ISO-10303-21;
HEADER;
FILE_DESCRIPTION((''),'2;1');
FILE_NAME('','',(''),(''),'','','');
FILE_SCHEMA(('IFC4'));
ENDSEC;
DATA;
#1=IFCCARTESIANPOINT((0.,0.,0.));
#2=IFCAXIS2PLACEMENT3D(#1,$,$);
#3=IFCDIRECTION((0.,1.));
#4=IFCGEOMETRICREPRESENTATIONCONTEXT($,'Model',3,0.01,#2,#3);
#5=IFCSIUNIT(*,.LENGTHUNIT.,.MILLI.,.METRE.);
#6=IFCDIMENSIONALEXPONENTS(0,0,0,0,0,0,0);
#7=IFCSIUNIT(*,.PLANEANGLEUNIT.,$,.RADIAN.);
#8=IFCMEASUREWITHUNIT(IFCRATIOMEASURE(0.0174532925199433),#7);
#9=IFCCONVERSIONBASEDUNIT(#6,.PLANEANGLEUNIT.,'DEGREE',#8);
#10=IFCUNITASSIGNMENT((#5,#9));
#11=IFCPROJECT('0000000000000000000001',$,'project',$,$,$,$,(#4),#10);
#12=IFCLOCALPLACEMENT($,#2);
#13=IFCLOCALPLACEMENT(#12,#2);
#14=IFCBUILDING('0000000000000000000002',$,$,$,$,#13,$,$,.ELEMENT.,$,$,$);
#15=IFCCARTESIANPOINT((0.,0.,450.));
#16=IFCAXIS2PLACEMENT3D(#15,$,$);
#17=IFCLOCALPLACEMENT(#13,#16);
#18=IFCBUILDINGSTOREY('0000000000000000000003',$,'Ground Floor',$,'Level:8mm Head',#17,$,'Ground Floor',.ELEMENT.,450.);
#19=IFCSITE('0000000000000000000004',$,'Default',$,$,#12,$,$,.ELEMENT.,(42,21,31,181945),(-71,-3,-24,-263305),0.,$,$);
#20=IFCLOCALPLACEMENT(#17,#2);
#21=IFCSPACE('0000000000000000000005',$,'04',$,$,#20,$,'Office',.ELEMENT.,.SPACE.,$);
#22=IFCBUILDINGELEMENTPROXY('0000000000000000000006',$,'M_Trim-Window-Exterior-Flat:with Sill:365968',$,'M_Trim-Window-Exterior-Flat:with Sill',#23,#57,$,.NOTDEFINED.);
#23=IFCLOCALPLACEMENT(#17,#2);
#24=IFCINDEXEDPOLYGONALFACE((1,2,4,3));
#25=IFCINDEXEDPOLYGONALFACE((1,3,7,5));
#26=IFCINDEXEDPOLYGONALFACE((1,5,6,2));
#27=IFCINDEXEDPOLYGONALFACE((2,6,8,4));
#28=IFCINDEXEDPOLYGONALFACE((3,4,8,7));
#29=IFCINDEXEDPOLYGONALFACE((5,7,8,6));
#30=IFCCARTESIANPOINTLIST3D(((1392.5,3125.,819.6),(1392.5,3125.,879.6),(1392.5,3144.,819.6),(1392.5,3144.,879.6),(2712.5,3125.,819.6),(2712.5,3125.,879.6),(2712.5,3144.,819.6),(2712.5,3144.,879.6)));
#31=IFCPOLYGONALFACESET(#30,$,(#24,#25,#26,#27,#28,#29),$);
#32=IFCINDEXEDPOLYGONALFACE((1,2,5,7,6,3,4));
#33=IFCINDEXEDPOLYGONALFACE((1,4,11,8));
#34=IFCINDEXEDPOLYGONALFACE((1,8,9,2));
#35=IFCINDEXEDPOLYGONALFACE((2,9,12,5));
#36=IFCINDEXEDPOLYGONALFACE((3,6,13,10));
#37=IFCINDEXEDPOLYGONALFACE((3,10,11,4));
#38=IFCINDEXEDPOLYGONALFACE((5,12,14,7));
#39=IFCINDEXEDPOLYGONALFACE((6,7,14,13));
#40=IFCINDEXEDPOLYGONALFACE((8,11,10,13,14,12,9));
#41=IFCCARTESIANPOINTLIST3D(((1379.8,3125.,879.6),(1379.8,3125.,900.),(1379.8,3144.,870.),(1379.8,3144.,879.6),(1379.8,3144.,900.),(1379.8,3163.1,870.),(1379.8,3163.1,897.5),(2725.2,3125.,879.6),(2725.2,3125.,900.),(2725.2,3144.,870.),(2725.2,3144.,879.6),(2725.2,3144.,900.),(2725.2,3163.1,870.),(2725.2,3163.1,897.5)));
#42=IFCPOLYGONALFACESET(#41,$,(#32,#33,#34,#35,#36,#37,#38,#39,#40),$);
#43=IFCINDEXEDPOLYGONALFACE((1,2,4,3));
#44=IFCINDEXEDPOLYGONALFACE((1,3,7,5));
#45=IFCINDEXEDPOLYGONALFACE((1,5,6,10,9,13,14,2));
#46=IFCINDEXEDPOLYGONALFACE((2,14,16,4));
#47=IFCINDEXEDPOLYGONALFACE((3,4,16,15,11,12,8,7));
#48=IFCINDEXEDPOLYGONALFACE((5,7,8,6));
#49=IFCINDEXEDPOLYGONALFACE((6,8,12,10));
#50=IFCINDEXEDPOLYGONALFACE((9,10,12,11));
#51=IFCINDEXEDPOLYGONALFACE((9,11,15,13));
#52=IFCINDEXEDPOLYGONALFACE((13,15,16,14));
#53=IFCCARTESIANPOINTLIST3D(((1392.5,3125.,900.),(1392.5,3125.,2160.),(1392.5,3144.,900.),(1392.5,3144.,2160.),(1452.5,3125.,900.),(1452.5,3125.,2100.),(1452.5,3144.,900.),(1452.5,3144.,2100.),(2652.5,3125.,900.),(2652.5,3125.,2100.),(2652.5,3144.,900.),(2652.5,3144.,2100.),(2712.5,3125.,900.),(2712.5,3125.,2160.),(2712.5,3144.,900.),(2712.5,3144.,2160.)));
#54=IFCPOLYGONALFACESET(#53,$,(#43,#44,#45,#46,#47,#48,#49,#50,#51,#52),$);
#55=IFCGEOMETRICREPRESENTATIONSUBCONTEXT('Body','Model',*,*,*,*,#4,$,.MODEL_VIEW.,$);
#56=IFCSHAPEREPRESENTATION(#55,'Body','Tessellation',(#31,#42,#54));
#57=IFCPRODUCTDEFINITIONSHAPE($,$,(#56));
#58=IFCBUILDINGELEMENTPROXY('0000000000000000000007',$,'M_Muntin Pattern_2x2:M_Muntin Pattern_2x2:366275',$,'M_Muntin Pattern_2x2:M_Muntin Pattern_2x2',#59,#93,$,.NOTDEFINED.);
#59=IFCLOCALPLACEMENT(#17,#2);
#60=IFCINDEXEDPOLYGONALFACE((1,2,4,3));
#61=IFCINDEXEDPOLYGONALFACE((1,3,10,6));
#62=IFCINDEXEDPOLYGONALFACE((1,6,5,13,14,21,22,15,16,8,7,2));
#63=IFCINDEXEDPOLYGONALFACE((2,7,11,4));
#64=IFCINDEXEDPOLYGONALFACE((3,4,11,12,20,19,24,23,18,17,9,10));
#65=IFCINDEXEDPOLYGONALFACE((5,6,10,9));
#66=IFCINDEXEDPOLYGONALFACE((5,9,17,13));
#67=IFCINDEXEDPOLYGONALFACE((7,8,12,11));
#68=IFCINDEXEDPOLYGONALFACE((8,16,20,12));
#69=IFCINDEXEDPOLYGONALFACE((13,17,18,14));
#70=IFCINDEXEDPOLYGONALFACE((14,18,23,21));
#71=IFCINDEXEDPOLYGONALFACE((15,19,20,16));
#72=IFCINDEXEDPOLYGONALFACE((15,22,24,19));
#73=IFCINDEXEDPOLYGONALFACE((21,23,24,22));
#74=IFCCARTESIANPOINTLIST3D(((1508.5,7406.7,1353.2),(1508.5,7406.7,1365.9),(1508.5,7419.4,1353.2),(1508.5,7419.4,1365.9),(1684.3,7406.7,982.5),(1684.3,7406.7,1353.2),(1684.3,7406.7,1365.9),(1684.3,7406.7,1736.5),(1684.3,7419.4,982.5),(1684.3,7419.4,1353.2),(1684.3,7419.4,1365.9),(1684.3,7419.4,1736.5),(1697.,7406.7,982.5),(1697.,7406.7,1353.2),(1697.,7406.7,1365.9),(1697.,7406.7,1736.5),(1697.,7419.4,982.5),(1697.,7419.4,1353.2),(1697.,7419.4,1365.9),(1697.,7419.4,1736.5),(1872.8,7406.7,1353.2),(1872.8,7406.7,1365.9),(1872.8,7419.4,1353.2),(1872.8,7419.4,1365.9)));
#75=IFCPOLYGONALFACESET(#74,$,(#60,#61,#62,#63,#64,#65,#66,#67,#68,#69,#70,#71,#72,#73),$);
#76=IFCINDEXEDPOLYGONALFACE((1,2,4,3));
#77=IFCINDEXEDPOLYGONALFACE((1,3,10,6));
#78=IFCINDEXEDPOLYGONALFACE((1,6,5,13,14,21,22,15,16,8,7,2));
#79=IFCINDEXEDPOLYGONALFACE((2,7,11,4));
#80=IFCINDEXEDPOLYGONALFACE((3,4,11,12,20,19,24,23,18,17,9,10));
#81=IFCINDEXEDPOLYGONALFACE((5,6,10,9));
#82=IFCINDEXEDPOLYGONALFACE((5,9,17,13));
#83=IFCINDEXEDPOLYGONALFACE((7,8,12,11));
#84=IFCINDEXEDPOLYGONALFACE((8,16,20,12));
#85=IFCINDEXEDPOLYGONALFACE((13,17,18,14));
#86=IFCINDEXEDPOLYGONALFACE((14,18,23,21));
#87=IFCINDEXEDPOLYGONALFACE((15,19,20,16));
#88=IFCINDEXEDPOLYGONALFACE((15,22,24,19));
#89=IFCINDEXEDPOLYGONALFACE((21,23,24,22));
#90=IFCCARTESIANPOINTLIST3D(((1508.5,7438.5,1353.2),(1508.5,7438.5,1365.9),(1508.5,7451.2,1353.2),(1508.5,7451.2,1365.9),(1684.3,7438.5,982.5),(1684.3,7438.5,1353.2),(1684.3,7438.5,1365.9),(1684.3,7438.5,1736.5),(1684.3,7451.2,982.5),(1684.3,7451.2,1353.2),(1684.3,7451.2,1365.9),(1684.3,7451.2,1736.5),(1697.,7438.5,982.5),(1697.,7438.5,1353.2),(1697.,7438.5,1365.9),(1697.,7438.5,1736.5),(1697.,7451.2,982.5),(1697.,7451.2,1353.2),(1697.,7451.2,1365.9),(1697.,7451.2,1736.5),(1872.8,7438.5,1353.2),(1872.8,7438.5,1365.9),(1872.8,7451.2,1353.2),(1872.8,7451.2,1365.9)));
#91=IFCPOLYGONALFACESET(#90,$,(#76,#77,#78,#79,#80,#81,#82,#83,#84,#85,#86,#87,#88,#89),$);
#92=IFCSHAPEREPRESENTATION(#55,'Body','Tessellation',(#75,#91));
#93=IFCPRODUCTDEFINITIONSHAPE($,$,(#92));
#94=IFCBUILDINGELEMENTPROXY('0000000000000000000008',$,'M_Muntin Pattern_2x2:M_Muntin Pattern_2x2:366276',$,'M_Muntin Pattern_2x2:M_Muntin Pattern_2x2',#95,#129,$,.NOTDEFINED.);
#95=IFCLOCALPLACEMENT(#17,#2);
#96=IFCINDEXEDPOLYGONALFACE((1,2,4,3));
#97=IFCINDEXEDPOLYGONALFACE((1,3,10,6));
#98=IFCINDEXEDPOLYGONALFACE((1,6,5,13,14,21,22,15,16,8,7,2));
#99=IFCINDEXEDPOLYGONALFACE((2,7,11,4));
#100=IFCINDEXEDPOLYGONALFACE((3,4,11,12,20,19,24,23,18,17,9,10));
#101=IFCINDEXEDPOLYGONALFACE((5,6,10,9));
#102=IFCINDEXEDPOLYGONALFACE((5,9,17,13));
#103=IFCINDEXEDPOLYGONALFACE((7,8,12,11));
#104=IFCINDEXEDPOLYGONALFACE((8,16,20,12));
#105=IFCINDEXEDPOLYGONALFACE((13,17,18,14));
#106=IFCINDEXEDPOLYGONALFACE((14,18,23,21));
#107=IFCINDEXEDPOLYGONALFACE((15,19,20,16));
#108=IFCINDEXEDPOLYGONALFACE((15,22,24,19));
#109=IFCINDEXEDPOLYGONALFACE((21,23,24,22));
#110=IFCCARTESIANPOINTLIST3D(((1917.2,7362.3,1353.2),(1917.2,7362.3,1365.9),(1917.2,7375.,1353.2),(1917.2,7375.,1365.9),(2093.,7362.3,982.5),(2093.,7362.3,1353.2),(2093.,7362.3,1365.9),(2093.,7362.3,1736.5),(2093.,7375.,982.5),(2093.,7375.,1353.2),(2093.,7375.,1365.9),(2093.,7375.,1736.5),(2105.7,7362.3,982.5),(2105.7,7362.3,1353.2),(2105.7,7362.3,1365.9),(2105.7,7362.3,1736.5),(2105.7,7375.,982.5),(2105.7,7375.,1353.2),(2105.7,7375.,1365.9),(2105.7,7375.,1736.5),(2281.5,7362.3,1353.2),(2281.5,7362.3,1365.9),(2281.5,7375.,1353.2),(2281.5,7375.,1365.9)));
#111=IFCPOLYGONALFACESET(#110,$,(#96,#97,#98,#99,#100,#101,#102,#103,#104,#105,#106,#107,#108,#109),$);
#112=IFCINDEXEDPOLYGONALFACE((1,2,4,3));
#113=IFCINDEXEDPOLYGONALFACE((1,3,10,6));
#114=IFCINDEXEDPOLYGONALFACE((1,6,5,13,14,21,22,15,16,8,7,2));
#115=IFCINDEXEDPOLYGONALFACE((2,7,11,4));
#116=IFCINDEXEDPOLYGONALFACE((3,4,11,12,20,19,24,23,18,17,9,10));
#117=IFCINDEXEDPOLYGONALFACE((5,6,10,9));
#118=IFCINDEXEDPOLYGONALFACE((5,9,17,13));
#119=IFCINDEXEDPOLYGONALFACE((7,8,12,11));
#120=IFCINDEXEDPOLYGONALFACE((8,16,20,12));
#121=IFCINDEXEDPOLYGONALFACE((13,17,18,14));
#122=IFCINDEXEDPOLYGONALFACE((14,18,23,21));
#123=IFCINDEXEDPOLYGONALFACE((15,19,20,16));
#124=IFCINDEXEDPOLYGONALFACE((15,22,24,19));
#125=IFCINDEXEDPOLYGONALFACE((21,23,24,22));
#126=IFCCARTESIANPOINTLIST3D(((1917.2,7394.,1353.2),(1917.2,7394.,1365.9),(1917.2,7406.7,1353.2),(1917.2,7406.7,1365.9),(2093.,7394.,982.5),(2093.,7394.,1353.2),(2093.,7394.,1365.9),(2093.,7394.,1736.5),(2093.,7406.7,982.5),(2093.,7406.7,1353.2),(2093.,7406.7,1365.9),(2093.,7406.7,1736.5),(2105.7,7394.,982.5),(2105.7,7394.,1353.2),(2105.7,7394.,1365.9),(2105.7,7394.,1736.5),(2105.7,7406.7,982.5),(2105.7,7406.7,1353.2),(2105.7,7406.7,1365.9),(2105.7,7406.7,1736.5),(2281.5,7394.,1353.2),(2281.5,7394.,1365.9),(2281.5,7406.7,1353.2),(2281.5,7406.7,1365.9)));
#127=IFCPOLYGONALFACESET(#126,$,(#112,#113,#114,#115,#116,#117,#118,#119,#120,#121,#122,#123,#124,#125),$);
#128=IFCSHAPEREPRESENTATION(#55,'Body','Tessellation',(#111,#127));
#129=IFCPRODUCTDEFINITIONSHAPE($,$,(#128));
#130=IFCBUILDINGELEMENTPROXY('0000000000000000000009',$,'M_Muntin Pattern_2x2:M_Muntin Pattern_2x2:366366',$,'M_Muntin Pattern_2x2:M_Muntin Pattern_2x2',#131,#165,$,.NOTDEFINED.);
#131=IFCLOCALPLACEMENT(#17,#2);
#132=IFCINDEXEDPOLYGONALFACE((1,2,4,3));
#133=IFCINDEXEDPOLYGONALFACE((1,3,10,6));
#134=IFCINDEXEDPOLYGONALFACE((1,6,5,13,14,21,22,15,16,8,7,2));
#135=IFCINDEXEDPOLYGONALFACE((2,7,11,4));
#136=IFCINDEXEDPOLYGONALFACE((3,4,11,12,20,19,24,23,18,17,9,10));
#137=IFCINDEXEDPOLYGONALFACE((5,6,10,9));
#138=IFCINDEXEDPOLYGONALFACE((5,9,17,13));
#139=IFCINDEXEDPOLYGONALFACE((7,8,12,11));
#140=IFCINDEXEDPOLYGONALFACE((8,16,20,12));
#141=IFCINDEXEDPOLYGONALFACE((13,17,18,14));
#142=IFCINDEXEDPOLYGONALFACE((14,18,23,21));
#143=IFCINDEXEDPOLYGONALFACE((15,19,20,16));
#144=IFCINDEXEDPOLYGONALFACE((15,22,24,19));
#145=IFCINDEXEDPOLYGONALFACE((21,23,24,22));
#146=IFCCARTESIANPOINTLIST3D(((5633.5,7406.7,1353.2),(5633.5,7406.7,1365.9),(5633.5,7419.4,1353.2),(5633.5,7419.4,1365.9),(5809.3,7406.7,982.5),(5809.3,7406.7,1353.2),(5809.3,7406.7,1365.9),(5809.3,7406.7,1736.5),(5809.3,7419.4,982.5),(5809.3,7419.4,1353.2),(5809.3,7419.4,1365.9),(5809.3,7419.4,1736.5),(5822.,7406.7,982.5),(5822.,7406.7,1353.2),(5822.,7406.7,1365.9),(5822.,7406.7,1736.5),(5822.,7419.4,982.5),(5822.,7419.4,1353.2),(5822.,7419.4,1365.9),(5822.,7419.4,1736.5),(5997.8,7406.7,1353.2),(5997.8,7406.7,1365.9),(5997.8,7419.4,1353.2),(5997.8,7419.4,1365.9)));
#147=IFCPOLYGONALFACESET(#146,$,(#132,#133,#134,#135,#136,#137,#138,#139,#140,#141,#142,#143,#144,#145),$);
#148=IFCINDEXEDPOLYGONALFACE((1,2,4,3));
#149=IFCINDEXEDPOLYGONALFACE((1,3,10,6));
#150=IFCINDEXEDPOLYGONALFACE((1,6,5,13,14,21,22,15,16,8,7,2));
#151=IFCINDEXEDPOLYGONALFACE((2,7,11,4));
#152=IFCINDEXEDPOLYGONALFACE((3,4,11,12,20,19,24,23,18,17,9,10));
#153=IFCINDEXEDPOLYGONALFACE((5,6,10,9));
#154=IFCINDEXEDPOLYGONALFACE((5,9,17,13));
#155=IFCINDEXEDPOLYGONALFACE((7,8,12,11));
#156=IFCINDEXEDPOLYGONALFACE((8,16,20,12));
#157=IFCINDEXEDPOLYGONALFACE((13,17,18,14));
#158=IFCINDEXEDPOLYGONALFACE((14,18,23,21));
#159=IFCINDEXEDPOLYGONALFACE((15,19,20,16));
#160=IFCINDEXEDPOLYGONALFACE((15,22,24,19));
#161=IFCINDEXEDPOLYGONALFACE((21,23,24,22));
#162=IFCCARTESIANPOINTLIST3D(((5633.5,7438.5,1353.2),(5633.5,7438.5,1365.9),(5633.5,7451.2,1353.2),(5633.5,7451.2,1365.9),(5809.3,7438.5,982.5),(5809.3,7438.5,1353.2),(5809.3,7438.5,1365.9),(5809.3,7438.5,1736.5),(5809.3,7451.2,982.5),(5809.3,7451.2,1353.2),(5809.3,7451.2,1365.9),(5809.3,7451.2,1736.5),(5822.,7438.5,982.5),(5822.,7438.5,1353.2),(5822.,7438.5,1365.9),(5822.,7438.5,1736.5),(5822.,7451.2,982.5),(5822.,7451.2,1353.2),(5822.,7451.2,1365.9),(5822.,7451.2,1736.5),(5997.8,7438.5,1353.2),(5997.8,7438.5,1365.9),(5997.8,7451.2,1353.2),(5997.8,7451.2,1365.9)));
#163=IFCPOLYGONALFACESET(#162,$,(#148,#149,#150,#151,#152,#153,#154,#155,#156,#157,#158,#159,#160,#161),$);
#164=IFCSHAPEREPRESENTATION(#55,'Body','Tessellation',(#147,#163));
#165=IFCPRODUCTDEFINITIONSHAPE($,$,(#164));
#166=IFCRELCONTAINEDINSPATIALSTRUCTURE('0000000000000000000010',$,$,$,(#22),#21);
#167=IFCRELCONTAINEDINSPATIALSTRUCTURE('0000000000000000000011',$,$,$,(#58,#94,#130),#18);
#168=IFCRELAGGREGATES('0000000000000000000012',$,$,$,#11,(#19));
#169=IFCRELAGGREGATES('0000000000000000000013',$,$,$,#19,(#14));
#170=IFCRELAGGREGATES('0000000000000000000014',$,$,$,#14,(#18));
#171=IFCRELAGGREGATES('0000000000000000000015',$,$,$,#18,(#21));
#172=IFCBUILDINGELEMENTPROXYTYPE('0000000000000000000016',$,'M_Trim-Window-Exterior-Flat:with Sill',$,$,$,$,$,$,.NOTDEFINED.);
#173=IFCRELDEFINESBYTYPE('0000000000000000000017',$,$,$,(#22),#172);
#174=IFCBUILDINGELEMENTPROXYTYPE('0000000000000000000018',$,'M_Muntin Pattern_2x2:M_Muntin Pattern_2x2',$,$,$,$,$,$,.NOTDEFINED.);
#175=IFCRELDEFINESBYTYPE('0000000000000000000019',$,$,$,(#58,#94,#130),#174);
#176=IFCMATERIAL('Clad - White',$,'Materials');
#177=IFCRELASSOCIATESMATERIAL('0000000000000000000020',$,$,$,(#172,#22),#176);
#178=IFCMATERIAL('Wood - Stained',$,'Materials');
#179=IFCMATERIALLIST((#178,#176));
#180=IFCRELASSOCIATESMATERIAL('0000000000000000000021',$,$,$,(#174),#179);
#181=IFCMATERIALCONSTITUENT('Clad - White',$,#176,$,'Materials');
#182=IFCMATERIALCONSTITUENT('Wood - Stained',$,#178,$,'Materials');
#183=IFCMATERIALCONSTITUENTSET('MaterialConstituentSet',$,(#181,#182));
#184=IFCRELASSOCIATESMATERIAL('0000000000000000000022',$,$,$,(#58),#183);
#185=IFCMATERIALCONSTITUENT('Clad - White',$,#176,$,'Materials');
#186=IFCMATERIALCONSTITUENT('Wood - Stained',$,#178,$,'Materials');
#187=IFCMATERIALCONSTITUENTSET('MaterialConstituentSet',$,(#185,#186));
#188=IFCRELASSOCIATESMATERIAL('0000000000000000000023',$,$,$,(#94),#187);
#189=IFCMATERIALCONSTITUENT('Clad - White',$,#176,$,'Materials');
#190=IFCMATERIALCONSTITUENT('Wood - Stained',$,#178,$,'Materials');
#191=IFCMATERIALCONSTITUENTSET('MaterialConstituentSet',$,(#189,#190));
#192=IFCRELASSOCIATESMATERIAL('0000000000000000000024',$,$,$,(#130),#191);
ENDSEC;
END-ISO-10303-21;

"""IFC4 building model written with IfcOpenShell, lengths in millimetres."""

from ifc_helpers import new_model, entity, si_unit, converted_unit, direction, frame, frame_2d, origin, place, context, subcontext, project, spatial, polyline, rectangle, outline, extrude, source, transform, mapped, material, material_list, constituent, constituent_set, type_object, type_shapes, element, save


model = new_model("IFC4")

# Units and contexts
model_context = context("Model", 3, precision=0.01, world=origin(), true_north=direction((0.0, 1.0)))
body_context = subcontext(model_context, "Body", "Model", "MODEL_VIEW")
ifc_project = project(units=[si_unit("LENGTHUNIT", "METRE", prefix="MILLI"), converted_unit("PLANEANGLEUNIT", "DEGREE", entity("IfcRatioMeasure", 0.0174532925199433), si_unit("PLANEANGLEUNIT", "RADIAN"), dimensions=[0, 0, 0, 0, 0, 0, 0])], contexts=[model_context])

# Site, building, storey
site_placement = place(None, origin())
site = spatial("IfcSite", under=ifc_project, at=site_placement, Name="Default", CompositionType="ELEMENT", RefLatitude=(42, 21, 31, 181945), RefLongitude=(-71, -3, -24, -263305), RefElevation=0.0)
building_placement = place(site_placement, origin())
building = spatial("IfcBuilding", under=site, at=building_placement, CompositionType="ELEMENT")
storey_placement = place(building_placement, frame((0.0, 0.0, 450.0)))
storey = spatial("IfcBuildingStorey", under=building, at=storey_placement, Name="Ground Floor", ObjectType="Level:8mm Head", LongName="Ground Floor", CompositionType="ELEMENT", Elevation=450.0)

# Shared definitions
space_1_placement = place(storey_placement, origin())
space_1 = spatial("IfcSpace", under=storey, at=space_1_placement, Name="04", LongName="Office", CompositionType="ELEMENT", PredefinedType="SPACE")

# Building element proxies
ifc_material_1 = material(Name="Clad - White", Category="Materials")
building_element_proxy_type_1 = type_object("IfcBuildingElementProxyType", Name="M_Trim-Window-Exterior-Flat:with Sill", PredefinedType="NOTDEFINED", material=ifc_material_1)
shared_shape_1 = source(origin(), body_context, "Body", "SweptSolid", [
    extrude(rectangle(XDim=1320.0, YDim=60.0, at=frame_2d((0.0, 0.0), x_axis=(1.0, 0.0))), frame((0.0, -1250.4, 0.0), z_axis=(0.0, 0.0, 1.0), x_axis=(-1.0, 0.0, 0.0)), (0.0, 0.0, 1.0), 19.1),
    extrude(outline(polyline([(-19.0, -15.2), (0.0, -15.2), (0.0, -5.7), (19.0, -5.7), (19.0, 14.8), (0.0, 14.8), (-19.0, 12.3), (-19.0, -15.2)])), frame((-672.7, -1214.8, 19.0), z_axis=(1.0, 0.0, 0.0), x_axis=(0.0, 0.0, -1.0)), (0.0, 0.0, 1.0), 1345.4),
    extrude(outline(polyline([(-645.0, -660.0), (615.0, -660.0), (615.0, -600.0), (-585.0, -600.0), (-585.0, 600.0), (615.0, 600.0), (615.0, 660.0), (-645.0, 660.0), (-645.0, -660.0)])), frame((0.0, -585.0, 0.0), z_axis=(0.0, 0.0, 1.0), x_axis=(0.0, -1.0, 0.0)), (0.0, 0.0, 1.0), 19.1),
])
type_shapes(building_element_proxy_type_1, [shared_shape_1])
proxy_1_placement = place(space_1_placement, frame((2052.5, 3125.0, 2100.0), z_axis=(0.0, 1.0, 0.0), x_axis=(-1.0, 0.0, 0.0)))
element("IfcBuildingElementProxy", 1, at=proxy_1_placement, inside=space_1, type_object=building_element_proxy_type_1, material=ifc_material_1, Name="M_Trim-Window-Exterior-Flat:with Sill:365968", ObjectType="M_Trim-Window-Exterior-Flat:with Sill", PredefinedType="NOTDEFINED", context=body_context, shape_type="MappedRepresentation", body=[
    mapped(shared_shape_1, transform((0.0, 0.0, 0.0), scale=1.0)),
])
ifc_constituent_1 = constituent(ifc_material_1, Name="Clad - White", Category="Materials")
ifc_material_2 = material(Name="Wood - Stained", Category="Materials")
ifc_constituent_2 = constituent(ifc_material_2, Name="Wood - Stained", Category="Materials")
ifc_constituent_set_1 = constituent_set(constituents=[ifc_constituent_1, ifc_constituent_2], Name="MaterialConstituentSet")
ifc_material_list_1 = material_list([ifc_material_2, ifc_material_1])
building_element_proxy_type_2 = type_object("IfcBuildingElementProxyType", Name="M_Muntin Pattern_2x2:M_Muntin Pattern_2x2", PredefinedType="NOTDEFINED", material=ifc_material_list_1)
shared_shape_2 = source(origin(), body_context, "Body", "SweptSolid", [
    extrude(outline(polyline([(6.4, -6.4), (377.0, -6.4), (377.0, 6.3), (6.4, 6.3), (6.4, 182.1), (-6.3, 182.1), (-6.3, 6.3), (-377.0, 6.3), (-377.0, -6.4), (-6.3, -6.4), (-6.3, -182.1), (6.4, -182.1), (6.4, -6.4)])), frame((0.0, 9.5, 377.0), z_axis=(0.0, 1.0, 0.0), x_axis=(0.0, 0.0, 1.0)), (0.0, 0.0, 1.0), 12.7),
    extrude(outline(polyline([(6.4, -6.4), (377.0, -6.4), (377.0, 6.3), (6.4, 6.3), (6.4, 182.1), (-6.3, 182.1), (-6.3, 6.3), (-377.0, 6.3), (-377.0, -6.4), (-6.3, -6.4), (-6.3, -182.1), (6.4, -182.1), (6.4, -6.4)])), frame((0.0, -22.2, 377.0), z_axis=(0.0, 1.0, 0.0), x_axis=(0.0, 0.0, 1.0)), (0.0, 0.0, 1.0), 12.7),
])
type_shapes(building_element_proxy_type_2, [shared_shape_2])
proxy_2_placement = place(storey_placement, frame((1690.6, 7429.0, 982.5), z_axis=(0.0, 0.0, 1.0), x_axis=(-1.0, 0.0, 0.0)))
element("IfcBuildingElementProxy", 2, at=proxy_2_placement, inside=storey, type_object=building_element_proxy_type_2, material=ifc_constituent_set_1, Name="M_Muntin Pattern_2x2:M_Muntin Pattern_2x2:366275", ObjectType="M_Muntin Pattern_2x2:M_Muntin Pattern_2x2", PredefinedType="NOTDEFINED", context=body_context, shape_type="MappedRepresentation", body=[
    mapped(shared_shape_2, transform((0.0, 0.0, 0.0), scale=1.0)),
])
ifc_constituent_3 = constituent(ifc_material_1, Name="Clad - White", Category="Materials")
ifc_constituent_4 = constituent(ifc_material_2, Name="Wood - Stained", Category="Materials")
ifc_constituent_set_2 = constituent_set(constituents=[ifc_constituent_3, ifc_constituent_4], Name="MaterialConstituentSet")
proxy_3_placement = place(storey_placement, frame((2099.4, 7384.5, 982.5), z_axis=(0.0, 0.0, 1.0), x_axis=(-1.0, 0.0, 0.0)))
element("IfcBuildingElementProxy", 3, at=proxy_3_placement, inside=storey, type_object=building_element_proxy_type_2, material=ifc_constituent_set_2, Name="M_Muntin Pattern_2x2:M_Muntin Pattern_2x2:366276", ObjectType="M_Muntin Pattern_2x2:M_Muntin Pattern_2x2", PredefinedType="NOTDEFINED", context=body_context, shape_type="MappedRepresentation", body=[
    mapped(shared_shape_2, transform((0.0, 0.0, 0.0), scale=1.0)),
])
ifc_constituent_5 = constituent(ifc_material_1, Name="Clad - White", Category="Materials")
ifc_constituent_6 = constituent(ifc_material_2, Name="Wood - Stained", Category="Materials")
ifc_constituent_set_3 = constituent_set(constituents=[ifc_constituent_5, ifc_constituent_6], Name="MaterialConstituentSet")
proxy_4_placement = place(storey_placement, frame((5815.6, 7429.0, 982.5), z_axis=(0.0, 0.0, 1.0), x_axis=(-1.0, 0.0, 0.0)))
element("IfcBuildingElementProxy", 4, at=proxy_4_placement, inside=storey, type_object=building_element_proxy_type_2, material=ifc_constituent_set_3, Name="M_Muntin Pattern_2x2:M_Muntin Pattern_2x2:366366", ObjectType="M_Muntin Pattern_2x2:M_Muntin Pattern_2x2", PredefinedType="NOTDEFINED", context=body_context, shape_type="MappedRepresentation", body=[
    mapped(shared_shape_2, transform((0.0, 0.0, 0.0), scale=1.0)),
])

save(model, "model.ifc")
